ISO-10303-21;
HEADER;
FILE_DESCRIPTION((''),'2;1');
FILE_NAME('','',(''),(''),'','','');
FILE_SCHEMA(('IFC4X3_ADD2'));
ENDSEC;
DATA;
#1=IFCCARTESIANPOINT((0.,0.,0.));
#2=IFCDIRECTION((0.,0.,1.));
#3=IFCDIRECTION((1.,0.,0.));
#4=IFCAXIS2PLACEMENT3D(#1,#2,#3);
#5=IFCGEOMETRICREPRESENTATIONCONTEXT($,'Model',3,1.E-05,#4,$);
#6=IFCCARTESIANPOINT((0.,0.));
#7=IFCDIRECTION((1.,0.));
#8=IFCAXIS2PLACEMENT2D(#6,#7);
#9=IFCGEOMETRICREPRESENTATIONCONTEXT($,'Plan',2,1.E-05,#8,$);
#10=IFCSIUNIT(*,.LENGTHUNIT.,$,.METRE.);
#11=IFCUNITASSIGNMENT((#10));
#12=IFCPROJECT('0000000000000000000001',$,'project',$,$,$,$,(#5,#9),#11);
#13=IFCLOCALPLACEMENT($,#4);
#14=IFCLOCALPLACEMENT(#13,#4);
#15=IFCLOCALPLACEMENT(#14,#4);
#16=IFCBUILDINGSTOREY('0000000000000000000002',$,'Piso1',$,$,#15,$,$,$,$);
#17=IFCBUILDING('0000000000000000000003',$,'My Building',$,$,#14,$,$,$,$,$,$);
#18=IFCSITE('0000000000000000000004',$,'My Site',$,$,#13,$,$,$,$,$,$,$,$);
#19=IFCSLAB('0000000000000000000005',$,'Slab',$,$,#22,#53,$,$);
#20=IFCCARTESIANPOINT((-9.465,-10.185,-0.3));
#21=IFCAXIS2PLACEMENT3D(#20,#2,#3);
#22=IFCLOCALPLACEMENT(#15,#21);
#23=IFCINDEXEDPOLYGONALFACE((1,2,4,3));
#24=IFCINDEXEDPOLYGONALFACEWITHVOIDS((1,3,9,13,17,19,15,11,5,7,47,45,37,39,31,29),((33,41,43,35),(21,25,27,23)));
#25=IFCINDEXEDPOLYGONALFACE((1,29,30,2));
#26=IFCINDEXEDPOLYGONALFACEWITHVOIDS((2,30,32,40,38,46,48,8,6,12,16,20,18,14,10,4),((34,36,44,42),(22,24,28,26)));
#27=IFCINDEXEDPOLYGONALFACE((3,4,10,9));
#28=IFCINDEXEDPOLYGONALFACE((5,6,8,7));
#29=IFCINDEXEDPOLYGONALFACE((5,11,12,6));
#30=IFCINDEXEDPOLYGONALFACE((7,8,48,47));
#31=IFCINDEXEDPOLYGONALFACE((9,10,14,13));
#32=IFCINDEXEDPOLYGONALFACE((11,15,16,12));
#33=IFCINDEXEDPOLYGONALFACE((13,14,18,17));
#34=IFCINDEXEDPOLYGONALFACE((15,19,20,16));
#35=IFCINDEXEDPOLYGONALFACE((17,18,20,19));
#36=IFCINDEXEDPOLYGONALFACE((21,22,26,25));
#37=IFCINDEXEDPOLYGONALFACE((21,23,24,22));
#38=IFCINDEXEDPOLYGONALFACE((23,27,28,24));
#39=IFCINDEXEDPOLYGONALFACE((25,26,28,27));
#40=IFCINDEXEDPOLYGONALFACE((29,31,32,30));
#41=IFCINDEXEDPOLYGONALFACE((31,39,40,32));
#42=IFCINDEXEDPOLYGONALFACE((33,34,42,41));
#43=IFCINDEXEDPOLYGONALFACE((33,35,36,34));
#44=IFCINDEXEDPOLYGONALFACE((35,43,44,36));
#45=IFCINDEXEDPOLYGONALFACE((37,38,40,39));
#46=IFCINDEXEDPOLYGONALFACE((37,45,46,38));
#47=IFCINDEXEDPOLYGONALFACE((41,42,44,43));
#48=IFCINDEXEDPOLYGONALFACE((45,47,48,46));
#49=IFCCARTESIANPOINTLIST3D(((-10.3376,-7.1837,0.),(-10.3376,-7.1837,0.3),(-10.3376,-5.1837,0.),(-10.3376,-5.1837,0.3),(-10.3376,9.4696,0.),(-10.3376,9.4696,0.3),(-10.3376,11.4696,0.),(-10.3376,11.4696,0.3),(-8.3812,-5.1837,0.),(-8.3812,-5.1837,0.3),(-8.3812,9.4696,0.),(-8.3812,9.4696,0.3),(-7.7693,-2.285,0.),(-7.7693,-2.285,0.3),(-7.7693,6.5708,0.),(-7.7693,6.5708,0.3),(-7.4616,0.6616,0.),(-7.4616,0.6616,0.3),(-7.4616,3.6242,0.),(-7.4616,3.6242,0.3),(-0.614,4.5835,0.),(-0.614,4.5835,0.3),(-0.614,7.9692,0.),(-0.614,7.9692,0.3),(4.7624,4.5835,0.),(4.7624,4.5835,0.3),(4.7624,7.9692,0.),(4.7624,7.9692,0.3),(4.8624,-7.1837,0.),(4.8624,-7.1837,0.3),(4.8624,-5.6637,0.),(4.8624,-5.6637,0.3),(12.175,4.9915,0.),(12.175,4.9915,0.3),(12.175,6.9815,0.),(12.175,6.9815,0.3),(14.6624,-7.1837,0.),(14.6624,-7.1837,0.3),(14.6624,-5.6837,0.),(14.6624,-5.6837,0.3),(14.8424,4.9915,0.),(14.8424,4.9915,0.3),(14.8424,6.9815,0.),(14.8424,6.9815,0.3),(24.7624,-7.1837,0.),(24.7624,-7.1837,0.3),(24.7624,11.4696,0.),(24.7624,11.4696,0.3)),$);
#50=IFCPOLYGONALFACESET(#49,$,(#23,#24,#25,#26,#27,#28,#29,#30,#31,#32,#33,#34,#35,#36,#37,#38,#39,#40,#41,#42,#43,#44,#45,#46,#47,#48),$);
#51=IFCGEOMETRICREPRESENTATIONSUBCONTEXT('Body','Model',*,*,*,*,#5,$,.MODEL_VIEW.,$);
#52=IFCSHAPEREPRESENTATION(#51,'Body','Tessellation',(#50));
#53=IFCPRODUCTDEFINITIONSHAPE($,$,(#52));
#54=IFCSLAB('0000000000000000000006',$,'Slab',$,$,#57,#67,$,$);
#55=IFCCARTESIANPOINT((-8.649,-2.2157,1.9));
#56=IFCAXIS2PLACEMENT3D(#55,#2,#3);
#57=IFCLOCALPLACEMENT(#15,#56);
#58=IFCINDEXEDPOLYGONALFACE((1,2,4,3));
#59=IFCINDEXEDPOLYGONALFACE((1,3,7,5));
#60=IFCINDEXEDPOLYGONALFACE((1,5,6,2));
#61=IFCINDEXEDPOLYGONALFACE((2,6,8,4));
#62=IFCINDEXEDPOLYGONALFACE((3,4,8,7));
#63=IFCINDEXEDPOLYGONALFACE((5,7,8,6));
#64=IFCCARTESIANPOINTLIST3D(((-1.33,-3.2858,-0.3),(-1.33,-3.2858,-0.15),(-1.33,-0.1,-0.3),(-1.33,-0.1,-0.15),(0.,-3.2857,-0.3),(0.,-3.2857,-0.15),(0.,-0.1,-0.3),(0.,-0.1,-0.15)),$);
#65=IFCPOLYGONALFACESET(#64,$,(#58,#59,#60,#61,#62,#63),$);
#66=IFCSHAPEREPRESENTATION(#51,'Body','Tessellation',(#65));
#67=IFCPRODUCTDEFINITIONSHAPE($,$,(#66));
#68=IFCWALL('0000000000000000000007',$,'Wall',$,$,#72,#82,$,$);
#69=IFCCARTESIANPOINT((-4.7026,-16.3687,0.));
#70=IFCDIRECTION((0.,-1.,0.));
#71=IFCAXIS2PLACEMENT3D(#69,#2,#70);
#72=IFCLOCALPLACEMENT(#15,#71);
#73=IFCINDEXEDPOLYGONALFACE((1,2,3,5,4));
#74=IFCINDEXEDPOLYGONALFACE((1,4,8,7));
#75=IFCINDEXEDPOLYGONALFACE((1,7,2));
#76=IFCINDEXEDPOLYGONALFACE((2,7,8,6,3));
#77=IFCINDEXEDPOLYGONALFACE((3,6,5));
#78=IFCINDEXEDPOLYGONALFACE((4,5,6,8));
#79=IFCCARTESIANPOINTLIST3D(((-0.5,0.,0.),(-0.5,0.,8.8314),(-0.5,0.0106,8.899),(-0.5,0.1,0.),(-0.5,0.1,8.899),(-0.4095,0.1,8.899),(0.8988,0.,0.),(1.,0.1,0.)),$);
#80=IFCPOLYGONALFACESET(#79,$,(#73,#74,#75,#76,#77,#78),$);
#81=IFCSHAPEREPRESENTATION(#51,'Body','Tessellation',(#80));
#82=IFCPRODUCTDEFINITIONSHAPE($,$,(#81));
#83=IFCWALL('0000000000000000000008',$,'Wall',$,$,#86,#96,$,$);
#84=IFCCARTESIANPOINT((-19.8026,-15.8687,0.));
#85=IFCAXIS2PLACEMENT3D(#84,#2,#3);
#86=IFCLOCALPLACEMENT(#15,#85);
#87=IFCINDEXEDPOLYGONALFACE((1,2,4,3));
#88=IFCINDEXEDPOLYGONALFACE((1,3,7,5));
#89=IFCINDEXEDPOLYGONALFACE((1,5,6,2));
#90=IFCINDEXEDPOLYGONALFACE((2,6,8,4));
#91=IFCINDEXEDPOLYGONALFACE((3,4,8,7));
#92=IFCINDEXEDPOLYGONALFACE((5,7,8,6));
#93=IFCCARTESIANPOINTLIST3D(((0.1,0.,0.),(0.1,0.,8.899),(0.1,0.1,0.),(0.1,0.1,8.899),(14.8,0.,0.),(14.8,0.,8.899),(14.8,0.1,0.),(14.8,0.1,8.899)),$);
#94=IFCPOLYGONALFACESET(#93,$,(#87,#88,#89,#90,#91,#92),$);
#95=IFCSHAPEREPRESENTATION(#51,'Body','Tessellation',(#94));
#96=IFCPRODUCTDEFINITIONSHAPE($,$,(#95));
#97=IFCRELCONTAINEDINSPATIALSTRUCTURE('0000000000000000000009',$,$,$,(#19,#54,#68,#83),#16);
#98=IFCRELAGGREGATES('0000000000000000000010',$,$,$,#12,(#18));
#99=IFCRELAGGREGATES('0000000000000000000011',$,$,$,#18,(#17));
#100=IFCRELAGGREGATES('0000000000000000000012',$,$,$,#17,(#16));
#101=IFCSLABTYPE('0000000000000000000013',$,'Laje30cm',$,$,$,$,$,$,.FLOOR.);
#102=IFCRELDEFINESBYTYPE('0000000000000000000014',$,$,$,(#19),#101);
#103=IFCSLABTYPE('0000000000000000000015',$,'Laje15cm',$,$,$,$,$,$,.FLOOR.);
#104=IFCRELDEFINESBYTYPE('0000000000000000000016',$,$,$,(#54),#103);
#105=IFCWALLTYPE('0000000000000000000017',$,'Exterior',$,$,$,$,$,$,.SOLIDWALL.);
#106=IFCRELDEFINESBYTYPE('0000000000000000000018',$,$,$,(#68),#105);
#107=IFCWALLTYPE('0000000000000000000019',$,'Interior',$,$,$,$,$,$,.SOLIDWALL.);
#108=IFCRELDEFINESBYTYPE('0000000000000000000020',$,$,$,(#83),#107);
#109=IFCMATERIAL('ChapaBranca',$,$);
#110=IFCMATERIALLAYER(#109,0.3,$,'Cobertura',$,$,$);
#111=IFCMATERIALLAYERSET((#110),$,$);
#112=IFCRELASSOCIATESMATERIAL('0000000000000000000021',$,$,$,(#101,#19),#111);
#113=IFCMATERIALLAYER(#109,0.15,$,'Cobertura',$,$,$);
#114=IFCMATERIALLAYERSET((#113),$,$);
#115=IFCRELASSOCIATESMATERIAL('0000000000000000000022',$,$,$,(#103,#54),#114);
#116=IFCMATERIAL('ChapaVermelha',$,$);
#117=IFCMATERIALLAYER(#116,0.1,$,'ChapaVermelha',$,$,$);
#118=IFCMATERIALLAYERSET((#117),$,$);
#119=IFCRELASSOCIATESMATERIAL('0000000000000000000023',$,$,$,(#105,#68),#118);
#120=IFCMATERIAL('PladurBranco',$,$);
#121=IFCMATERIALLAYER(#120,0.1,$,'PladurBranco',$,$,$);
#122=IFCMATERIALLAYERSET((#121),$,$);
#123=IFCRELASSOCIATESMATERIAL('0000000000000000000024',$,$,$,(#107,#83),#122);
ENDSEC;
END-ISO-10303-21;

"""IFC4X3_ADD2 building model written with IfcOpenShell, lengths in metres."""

from ifc_helpers import new_model, si_unit, frame, origin_with_axes, origin_2d_with_axis, place, context, subcontext, project, spatial, line, indexed_curve, outline, extrude, boolean, material, layer, layer_set, layer_usage, type_object, element, save


model = new_model("IFC4X3_ADD2")

# Units and contexts
model_context = context("Model", 3, precision=1e-05, world=origin_with_axes())
plan_context = context("Plan", 2, precision=1e-05, world=origin_2d_with_axis())
body_context_1 = subcontext(model_context, "Body", "Model", "MODEL_VIEW")
ifc_project = project(units=[si_unit("LENGTHUNIT", "METRE")], contexts=[model_context, plan_context])

# Site, building, storey
site_placement = place(None, origin_with_axes())
site = spatial("IfcSite", under=ifc_project, at=site_placement, Name="My Site")
building_placement = place(site_placement, origin_with_axes())
building = spatial("IfcBuilding", under=site, at=building_placement, Name="My Building")
storey_placement = place(building_placement, origin_with_axes())
storey = spatial("IfcBuildingStorey", under=building, at=storey_placement, Name="Piso1")

# Shared definitions
ifc_material_1 = material(Name="ChapaBranca")

# Slabs
ifc_layer_1 = layer(ifc_material_1, 0.3, Name="Cobertura")
ifc_layer_set_1 = layer_set([ifc_layer_1])
ifc_layer_usage_1 = layer_usage(ifc_layer_set_1, "AXIS3", "POSITIVE", 0.0)
slab_type_1 = type_object("IfcSlabType", Name="Laje30cm", PredefinedType="FLOOR", material=ifc_layer_set_1)
slab_1_placement = place(storey_placement, frame((-9.465, -10.185, -0.3), z_axis=(0.0, 0.0, 1.0), x_axis=(1.0, 0.0, 0.0)))
element("IfcSlab", 1, at=slab_1_placement, inside=storey, type_object=slab_type_1, material=ifc_layer_usage_1, Name="Slab", context=body_context_1, shape_type="SweptSolid", body=[
    extrude(outline(indexed_curve([(-10.3376, 9.4696), (-8.3812, 9.4696), (-7.7693, 6.5708), (-7.4616, 3.6242), (-7.4616, 0.6616), (-7.7693, -2.285), (-8.3812, -5.1837), (-10.3376, -5.1837), (-10.3376, -7.1837), (4.8624, -7.1837), (4.8624, -5.6637), (14.6624, -5.6837), (14.6624, -7.1837), (24.7624, -7.1837), (24.7624, 11.4696), (-10.3376, 11.4696), (-10.3376, 9.4696)]), holes=[indexed_curve([(12.175, 6.9815), (14.8424, 6.9815), (14.8424, 4.9915), (12.175, 4.9915), (12.175, 6.9815)]), indexed_curve([(-0.614, 4.5835), (4.7624, 4.5835), (4.7624, 7.9692), (-0.614, 7.9692), (-0.614, 4.5835)])]), frame((0.0, 0.0, 0.0), z_axis=(0.0, 0.0, 1.0), x_axis=(1.0, 0.0, 0.0)), (0.0, 0.0, 1.0), 0.3),
])
ifc_layer_2 = layer(ifc_material_1, 0.15, Name="Cobertura")
ifc_layer_set_2 = layer_set([ifc_layer_2])
slab_type_2 = type_object("IfcSlabType", Name="Laje15cm", PredefinedType="FLOOR", material=ifc_layer_set_2)
ifc_layer_usage_2 = layer_usage(ifc_layer_set_2, "AXIS3", "POSITIVE", -0.3)
slab_2_placement = place(storey_placement, frame((-8.649, -2.2157, 1.9), z_axis=(0.0, 0.0, 1.0), x_axis=(1.0, 0.0, 0.0)))
element("IfcSlab", 2, at=slab_2_placement, inside=storey, type_object=slab_type_2, material=ifc_layer_usage_2, Name="Slab", context=body_context_1, shape_type="SweptSolid", body=[
    extrude(outline(indexed_curve([(0.0, -3.2857), (0.0, -0.1), (-1.33, -0.1), (-1.33, -3.2858), (0.0, -3.2857)])), frame((0.0, 0.0, -0.3), z_axis=(0.0, 0.0, 1.0), x_axis=(1.0, 0.0, 0.0)), (0.0, 0.0, 1.0), 0.15),
])

# Shared definitions
ifc_material_2 = material(Name="ChapaVermelha")
ifc_layer_3 = layer(ifc_material_2, 0.1, Name="ChapaVermelha")
ifc_layer_set_3 = layer_set([ifc_layer_3])
wall_type_1 = type_object("IfcWallType", Name="Exterior", PredefinedType="SOLIDWALL", material=ifc_layer_set_3)

# Walls
ifc_layer_usage_3 = layer_usage(ifc_layer_set_3, "AXIS2", "POSITIVE", 0.0)
wall_1_placement = place(storey_placement, frame((-4.7026, -16.3687, 0.0), z_axis=(0.0, 0.0, 1.0), x_axis=(0.0, -1.0, 0.0)))
element("IfcWall", 3, at=wall_1_placement, inside=storey, type_object=wall_type_1, material=ifc_layer_usage_3, Name="Wall", context=body_context_1, shape_type="CSG", body=[
    boolean("DIFFERENCE", extrude(outline(indexed_curve([(-0.5, 0.0), (-0.5, 0.1), (1.0, 0.1), (0.8988, 0.0)], segments=[line(1, 2, 3, 4, 1)])), origin_with_axes(), (0.0, 0.0, 1.0), 8.899), extrude(outline(indexed_curve([(0.8988, 0.0), (1.0, 0.1), (2.4095, 0.1), (2.4095, 0.0)], segments=[line(1, 2, 3, 4, 1)])), origin_with_axes(), (-0.156434, 0.0, 0.987688), 9.0099)),
])
ifc_material_3 = material(Name="PladurBranco")
ifc_layer_4 = layer(ifc_material_3, 0.1, Name="PladurBranco")
ifc_layer_set_4 = layer_set([ifc_layer_4])
ifc_layer_usage_4 = layer_usage(ifc_layer_set_4, "AXIS2", "POSITIVE", 0.0)
wall_type_2 = type_object("IfcWallType", Name="Interior", PredefinedType="SOLIDWALL", material=ifc_layer_set_4)
wall_2_placement = place(storey_placement, frame((-19.8026, -15.8687, 0.0), z_axis=(0.0, 0.0, 1.0), x_axis=(1.0, 0.0, 0.0)))
element("IfcWall", 4, at=wall_2_placement, inside=storey, type_object=wall_type_2, material=ifc_layer_usage_4, Name="Wall", context=body_context_1, shape_type="SweptSolid", body=[
    extrude(outline(indexed_curve([(0.1, 0.0), (0.1, 0.1), (14.8, 0.1), (14.8, 0.0)], segments=[line(1, 2, 3, 4, 1)])), origin_with_axes(), (0.0, 0.0, 1.0), 8.899),
])

save(model, "model.ifc")
